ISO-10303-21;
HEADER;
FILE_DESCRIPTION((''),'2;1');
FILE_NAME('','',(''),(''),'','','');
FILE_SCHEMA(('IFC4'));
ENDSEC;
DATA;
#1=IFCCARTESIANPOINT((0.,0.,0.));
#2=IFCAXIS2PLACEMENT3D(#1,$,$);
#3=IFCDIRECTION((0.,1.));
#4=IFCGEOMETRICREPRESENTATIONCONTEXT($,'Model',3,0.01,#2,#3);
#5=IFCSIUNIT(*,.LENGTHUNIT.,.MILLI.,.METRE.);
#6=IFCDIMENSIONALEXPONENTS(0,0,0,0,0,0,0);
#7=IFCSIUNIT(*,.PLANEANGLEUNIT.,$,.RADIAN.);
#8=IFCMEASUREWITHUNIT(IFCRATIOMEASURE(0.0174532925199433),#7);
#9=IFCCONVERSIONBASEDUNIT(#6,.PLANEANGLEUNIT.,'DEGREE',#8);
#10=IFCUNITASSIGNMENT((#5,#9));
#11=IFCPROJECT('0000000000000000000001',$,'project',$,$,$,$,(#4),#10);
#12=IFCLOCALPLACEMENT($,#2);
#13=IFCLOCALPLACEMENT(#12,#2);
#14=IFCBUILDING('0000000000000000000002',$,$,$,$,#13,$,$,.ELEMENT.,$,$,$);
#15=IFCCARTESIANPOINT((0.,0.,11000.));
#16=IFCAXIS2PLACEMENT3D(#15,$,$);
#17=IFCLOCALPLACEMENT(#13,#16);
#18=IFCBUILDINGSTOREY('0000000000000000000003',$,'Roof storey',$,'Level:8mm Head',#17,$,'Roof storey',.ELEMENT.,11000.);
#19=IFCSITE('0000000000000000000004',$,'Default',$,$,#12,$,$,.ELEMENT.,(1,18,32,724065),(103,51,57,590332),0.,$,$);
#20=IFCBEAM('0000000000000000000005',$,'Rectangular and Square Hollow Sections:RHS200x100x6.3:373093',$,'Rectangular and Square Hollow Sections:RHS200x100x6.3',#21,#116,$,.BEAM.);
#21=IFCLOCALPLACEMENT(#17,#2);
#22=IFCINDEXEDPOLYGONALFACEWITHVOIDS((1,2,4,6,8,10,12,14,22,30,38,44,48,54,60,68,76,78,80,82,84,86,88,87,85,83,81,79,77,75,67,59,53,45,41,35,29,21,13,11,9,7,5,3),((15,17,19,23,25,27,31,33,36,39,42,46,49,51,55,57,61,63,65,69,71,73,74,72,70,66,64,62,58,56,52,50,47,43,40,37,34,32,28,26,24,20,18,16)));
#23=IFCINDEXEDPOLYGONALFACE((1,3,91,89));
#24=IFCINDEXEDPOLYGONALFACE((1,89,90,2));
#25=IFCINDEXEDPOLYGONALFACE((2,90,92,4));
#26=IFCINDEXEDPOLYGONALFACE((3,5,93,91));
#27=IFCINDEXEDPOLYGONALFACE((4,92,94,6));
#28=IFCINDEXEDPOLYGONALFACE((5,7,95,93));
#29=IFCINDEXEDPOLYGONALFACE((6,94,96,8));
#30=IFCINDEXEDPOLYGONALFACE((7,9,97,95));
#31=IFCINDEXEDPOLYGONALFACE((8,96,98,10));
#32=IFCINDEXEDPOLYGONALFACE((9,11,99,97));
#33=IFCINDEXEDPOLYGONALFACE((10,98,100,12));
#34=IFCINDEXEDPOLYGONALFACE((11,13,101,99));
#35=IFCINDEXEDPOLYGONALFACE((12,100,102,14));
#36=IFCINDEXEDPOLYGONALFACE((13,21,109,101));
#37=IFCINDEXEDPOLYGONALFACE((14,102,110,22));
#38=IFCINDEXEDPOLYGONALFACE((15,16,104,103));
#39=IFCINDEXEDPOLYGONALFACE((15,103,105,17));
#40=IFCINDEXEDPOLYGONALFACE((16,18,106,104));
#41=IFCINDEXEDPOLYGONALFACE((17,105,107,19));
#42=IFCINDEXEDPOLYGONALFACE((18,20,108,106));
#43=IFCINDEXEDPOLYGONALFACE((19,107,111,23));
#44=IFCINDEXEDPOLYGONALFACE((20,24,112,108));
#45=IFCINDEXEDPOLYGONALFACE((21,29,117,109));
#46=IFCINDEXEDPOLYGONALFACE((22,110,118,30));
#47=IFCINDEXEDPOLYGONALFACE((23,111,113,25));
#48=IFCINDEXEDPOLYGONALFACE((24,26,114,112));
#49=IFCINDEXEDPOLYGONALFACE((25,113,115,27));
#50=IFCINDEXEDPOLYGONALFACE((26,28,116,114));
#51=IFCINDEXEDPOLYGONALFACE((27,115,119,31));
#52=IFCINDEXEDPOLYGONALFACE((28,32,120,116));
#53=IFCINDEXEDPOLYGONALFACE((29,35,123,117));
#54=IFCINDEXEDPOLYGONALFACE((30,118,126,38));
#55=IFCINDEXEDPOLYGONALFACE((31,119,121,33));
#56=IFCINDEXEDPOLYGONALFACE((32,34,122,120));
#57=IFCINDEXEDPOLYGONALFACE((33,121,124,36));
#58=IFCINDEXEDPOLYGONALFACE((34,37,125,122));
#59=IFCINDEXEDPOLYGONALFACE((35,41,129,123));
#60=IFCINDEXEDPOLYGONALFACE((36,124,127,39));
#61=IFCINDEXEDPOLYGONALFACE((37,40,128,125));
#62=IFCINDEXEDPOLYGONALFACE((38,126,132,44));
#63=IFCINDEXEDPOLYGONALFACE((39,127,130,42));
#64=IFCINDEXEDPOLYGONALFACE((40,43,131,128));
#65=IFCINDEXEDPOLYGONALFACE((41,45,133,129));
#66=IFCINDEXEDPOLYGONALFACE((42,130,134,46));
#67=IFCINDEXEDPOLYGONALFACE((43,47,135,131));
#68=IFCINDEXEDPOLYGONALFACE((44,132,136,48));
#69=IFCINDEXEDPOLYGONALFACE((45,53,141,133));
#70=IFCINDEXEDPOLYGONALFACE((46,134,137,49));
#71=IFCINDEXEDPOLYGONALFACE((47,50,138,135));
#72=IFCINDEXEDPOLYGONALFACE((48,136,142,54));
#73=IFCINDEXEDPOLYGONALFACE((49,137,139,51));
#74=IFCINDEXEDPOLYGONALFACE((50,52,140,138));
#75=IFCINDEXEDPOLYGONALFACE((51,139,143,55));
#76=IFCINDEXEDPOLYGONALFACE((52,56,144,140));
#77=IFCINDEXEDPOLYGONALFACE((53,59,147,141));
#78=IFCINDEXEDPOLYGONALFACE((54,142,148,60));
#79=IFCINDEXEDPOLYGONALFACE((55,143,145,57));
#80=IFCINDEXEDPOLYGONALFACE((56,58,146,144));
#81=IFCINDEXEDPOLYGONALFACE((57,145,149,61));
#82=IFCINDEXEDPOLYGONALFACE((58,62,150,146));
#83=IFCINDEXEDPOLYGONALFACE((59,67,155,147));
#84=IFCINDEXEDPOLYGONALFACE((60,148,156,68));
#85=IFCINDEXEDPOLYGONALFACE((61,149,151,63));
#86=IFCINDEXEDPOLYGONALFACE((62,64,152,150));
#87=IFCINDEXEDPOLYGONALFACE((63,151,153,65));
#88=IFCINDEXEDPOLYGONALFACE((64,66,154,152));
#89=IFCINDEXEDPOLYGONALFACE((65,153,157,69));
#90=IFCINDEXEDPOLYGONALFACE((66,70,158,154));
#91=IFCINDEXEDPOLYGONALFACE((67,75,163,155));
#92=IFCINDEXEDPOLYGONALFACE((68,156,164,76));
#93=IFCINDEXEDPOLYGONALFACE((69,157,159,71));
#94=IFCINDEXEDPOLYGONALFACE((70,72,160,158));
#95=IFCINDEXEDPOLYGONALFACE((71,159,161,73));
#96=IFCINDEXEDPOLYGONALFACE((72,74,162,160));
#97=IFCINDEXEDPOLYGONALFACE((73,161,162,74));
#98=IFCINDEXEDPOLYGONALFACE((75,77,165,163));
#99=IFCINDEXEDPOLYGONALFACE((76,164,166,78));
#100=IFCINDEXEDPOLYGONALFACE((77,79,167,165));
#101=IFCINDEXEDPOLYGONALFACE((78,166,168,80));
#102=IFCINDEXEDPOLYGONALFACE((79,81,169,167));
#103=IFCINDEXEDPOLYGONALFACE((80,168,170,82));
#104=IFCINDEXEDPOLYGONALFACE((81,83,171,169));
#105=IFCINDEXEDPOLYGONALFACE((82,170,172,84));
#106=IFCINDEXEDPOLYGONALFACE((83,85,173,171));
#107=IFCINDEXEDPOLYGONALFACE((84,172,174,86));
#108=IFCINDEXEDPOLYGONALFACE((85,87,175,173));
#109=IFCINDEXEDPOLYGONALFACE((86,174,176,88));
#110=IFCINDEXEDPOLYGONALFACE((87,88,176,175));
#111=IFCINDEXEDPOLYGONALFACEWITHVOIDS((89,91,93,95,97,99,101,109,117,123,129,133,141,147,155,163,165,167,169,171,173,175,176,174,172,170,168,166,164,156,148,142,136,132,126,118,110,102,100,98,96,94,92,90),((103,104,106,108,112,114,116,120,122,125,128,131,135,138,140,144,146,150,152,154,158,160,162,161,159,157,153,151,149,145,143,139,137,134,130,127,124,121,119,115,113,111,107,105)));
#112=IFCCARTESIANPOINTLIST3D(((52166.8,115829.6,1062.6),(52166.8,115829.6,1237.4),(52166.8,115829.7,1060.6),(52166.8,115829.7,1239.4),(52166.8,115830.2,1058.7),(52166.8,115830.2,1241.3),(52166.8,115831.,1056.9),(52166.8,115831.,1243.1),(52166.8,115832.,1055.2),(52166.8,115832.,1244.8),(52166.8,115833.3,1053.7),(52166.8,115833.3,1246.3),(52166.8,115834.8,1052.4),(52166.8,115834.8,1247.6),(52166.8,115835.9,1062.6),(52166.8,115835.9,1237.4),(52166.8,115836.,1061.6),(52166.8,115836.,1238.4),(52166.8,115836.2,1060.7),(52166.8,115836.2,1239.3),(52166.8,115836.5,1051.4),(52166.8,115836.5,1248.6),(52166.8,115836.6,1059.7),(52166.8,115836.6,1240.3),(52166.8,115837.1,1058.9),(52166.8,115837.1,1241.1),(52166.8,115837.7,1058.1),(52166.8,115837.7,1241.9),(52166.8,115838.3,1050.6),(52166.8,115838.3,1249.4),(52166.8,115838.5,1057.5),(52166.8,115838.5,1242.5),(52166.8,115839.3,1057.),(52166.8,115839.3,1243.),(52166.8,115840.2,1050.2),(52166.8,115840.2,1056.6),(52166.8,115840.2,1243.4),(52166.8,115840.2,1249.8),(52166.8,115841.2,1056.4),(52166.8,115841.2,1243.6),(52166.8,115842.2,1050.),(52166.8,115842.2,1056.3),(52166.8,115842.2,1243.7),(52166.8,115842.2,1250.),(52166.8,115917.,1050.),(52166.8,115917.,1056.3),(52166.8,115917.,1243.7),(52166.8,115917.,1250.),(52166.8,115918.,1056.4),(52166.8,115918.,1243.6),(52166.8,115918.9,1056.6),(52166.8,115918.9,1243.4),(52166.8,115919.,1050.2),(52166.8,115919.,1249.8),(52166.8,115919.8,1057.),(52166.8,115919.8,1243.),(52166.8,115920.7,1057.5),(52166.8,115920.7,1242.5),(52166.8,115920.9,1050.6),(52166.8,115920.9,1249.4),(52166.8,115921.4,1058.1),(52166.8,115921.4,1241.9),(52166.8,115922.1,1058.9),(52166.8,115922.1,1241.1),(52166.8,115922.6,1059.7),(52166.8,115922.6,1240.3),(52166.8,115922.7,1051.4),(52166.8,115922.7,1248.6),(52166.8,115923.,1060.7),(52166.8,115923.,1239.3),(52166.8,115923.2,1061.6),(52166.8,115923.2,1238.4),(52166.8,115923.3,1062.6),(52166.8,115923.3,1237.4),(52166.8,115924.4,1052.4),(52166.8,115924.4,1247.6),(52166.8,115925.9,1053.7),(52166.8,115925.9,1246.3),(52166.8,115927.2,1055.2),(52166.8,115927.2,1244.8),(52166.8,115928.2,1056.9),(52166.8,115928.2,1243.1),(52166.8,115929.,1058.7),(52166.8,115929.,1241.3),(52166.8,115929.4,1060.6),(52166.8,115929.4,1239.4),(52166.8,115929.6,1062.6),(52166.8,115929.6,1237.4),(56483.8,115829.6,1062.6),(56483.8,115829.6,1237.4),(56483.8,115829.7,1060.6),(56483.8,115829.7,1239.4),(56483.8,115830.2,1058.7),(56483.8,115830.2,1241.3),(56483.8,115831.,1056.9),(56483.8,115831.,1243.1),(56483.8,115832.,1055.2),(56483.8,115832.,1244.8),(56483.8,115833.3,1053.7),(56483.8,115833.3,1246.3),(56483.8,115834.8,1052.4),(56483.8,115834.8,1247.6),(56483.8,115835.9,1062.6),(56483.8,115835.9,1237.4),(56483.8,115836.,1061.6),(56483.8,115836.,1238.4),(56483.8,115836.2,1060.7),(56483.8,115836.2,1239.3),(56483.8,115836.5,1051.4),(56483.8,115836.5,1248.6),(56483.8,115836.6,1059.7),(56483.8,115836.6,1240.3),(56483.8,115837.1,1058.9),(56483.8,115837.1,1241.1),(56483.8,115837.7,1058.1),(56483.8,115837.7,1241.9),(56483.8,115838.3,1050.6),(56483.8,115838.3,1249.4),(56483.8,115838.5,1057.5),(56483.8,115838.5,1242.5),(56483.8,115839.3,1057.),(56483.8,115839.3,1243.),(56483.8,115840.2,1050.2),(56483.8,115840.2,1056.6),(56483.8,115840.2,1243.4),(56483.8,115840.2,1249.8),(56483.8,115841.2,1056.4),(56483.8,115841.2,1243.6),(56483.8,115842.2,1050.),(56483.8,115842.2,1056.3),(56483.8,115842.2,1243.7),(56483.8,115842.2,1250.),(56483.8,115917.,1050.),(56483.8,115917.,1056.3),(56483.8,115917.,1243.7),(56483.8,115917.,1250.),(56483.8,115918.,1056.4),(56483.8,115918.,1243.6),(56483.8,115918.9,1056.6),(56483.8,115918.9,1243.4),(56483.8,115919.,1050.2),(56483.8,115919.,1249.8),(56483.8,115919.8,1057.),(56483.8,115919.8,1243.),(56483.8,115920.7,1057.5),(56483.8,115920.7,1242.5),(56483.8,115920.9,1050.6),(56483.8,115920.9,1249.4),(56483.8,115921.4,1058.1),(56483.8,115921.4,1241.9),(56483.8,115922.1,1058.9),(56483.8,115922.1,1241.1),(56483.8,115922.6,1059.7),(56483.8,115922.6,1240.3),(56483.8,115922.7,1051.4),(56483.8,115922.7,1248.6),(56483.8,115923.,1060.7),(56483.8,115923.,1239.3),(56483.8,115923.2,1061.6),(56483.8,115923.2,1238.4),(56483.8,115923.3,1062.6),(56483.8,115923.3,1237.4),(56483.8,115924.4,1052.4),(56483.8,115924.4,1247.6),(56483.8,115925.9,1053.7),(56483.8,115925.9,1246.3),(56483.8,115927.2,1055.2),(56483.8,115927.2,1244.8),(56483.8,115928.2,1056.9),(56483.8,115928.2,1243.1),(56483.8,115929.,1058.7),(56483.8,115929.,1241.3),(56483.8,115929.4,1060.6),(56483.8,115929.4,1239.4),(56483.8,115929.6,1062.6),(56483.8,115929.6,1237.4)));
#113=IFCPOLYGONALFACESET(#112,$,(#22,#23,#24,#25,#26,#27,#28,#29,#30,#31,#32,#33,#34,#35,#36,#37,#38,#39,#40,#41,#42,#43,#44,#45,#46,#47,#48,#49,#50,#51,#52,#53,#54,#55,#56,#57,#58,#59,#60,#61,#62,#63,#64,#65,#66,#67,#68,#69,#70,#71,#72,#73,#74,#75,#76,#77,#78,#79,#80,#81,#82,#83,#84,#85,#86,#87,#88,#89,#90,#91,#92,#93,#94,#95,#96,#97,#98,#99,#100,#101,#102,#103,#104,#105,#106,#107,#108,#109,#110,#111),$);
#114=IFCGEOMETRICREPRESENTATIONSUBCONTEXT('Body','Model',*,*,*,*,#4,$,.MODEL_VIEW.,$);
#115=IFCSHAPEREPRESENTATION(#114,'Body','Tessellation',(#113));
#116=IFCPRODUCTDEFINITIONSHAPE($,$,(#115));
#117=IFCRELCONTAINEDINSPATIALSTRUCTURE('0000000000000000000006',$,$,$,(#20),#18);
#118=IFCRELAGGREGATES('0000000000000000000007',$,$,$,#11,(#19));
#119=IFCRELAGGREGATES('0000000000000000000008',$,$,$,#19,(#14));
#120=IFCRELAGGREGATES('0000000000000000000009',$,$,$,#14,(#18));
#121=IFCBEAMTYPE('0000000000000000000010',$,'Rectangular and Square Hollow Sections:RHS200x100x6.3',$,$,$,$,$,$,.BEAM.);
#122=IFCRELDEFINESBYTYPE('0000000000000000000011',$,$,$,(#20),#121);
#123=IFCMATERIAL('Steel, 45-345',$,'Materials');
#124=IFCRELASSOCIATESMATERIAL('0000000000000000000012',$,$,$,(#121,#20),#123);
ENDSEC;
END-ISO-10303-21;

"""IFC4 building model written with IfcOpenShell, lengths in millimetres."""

from ifc_helpers import new_model, entity, si_unit, converted_unit, direction, frame, origin, place, context, subcontext, project, spatial, indexed_curve, outline, extrude, source, transform, mapped, material, type_object, type_shapes, element, save


model = new_model("IFC4")

# Units and contexts
model_context = context("Model", 3, precision=0.01, world=origin(), true_north=direction((0.0, 1.0)))
body_context = subcontext(model_context, "Body", "Model", "MODEL_VIEW")
ifc_project = project(units=[si_unit("LENGTHUNIT", "METRE", prefix="MILLI"), converted_unit("PLANEANGLEUNIT", "DEGREE", entity("IfcRatioMeasure", 0.0174532925199433), si_unit("PLANEANGLEUNIT", "RADIAN"), dimensions=[0, 0, 0, 0, 0, 0, 0])], contexts=[model_context])

# Site, building, storey
site_placement = place(None, origin())
site = spatial("IfcSite", under=ifc_project, at=site_placement, Name="Default", CompositionType="ELEMENT", RefLatitude=(1, 18, 32, 724065), RefLongitude=(103, 51, 57, 590332), RefElevation=0.0)
building_placement = place(site_placement, origin())
building = spatial("IfcBuilding", under=site, at=building_placement, CompositionType="ELEMENT")
storey_placement = place(building_placement, frame((0.0, 0.0, 11000.0)))
storey = spatial("IfcBuildingStorey", under=building, at=storey_placement, Name="Roof storey", ObjectType="Level:8mm Head", LongName="Roof storey", CompositionType="ELEMENT", Elevation=11000.0)

# Shared definitions
ifc_material = material(Name="Steel, 45-345", Category="Materials")

# Beam
beam_type_1 = type_object("IfcBeamType", Name="Rectangular and Square Hollow Sections:RHS200x100x6.3", PredefinedType="BEAM", material=ifc_material)
shared_shape_1 = source(origin(), body_context, "Body", "SweptSolid", [
    extrude(outline(indexed_curve([(-50.0, -87.4), (-49.8, -89.4), (-49.4, -91.3), (-48.6, -93.1), (-47.6, -94.8), (-46.3, -96.3), (-44.8, -97.6), (-43.1, -98.6), (-41.3, -99.4), (-39.4, -99.8), (-37.4, -100.0), (37.4, -100.0), (39.4, -99.8), (41.3, -99.4), (43.1, -98.6), (44.8, -97.6), (46.3, -96.3), (47.6, -94.8), (48.6, -93.1), (49.4, -91.3), (49.8, -89.4), (50.0, -87.4), (50.0, 87.4), (49.8, 89.4), (49.4, 91.3), (48.6, 93.1), (47.6, 94.8), (46.3, 96.3), (44.8, 97.6), (43.1, 98.6), (41.3, 99.4), (39.4, 99.8), (37.4, 100.0), (-37.4, 100.0), (-39.4, 99.8), (-41.3, 99.4), (-43.1, 98.6), (-44.8, 97.6), (-46.3, 96.3), (-47.6, 94.8), (-48.6, 93.1), (-49.4, 91.3), (-49.8, 89.4), (-50.0, 87.4), (-50.0, -87.4)], self_intersect=False), holes=[indexed_curve([(37.4, -93.7), (-37.4, -93.7), (-38.4, -93.6), (-39.3, -93.4), (-40.3, -93.0), (-41.1, -92.5), (-41.9, -91.9), (-42.5, -91.1), (-43.0, -90.3), (-43.4, -89.3), (-43.6, -88.4), (-43.7, -87.4), (-43.7, 87.4), (-43.6, 88.4), (-43.4, 89.3), (-43.0, 90.3), (-42.5, 91.1), (-41.9, 91.9), (-41.1, 92.5), (-40.3, 93.0), (-39.3, 93.4), (-38.4, 93.6), (-37.4, 93.7), (37.4, 93.7), (38.4, 93.6), (39.3, 93.4), (40.3, 93.0), (41.1, 92.5), (41.9, 91.9), (42.5, 91.1), (43.0, 90.3), (43.4, 89.3), (43.6, 88.4), (43.7, 87.4), (43.7, -87.4), (43.6, -88.4), (43.4, -89.3), (43.0, -90.3), (42.5, -91.1), (41.9, -91.9), (41.1, -92.5), (40.3, -93.0), (39.3, -93.4), (38.4, -93.6), (37.4, -93.7)], self_intersect=False)]), frame((-2127.5, 0.0, 0.0), z_axis=(1.0, 0.0, 0.0), x_axis=(0.0, -1.0, 0.0)), (0.0, 0.0, 1.0), 4317.0),
])
type_shapes(beam_type_1, [shared_shape_1])
beam_1_placement = place(storey_placement, frame((54294.3, 115879.6, 1150.0)))
element("IfcBeam", 1, at=beam_1_placement, inside=storey, type_object=beam_type_1, material=ifc_material, Name="Rectangular and Square Hollow Sections:RHS200x100x6.3:373093", ObjectType="Rectangular and Square Hollow Sections:RHS200x100x6.3", PredefinedType="BEAM", context=body_context, shape_type="MappedRepresentation", body=[
    mapped(shared_shape_1, transform((0.0, 0.0, 0.0), scale=1.0)),
])

save(model, "model.ifc")
